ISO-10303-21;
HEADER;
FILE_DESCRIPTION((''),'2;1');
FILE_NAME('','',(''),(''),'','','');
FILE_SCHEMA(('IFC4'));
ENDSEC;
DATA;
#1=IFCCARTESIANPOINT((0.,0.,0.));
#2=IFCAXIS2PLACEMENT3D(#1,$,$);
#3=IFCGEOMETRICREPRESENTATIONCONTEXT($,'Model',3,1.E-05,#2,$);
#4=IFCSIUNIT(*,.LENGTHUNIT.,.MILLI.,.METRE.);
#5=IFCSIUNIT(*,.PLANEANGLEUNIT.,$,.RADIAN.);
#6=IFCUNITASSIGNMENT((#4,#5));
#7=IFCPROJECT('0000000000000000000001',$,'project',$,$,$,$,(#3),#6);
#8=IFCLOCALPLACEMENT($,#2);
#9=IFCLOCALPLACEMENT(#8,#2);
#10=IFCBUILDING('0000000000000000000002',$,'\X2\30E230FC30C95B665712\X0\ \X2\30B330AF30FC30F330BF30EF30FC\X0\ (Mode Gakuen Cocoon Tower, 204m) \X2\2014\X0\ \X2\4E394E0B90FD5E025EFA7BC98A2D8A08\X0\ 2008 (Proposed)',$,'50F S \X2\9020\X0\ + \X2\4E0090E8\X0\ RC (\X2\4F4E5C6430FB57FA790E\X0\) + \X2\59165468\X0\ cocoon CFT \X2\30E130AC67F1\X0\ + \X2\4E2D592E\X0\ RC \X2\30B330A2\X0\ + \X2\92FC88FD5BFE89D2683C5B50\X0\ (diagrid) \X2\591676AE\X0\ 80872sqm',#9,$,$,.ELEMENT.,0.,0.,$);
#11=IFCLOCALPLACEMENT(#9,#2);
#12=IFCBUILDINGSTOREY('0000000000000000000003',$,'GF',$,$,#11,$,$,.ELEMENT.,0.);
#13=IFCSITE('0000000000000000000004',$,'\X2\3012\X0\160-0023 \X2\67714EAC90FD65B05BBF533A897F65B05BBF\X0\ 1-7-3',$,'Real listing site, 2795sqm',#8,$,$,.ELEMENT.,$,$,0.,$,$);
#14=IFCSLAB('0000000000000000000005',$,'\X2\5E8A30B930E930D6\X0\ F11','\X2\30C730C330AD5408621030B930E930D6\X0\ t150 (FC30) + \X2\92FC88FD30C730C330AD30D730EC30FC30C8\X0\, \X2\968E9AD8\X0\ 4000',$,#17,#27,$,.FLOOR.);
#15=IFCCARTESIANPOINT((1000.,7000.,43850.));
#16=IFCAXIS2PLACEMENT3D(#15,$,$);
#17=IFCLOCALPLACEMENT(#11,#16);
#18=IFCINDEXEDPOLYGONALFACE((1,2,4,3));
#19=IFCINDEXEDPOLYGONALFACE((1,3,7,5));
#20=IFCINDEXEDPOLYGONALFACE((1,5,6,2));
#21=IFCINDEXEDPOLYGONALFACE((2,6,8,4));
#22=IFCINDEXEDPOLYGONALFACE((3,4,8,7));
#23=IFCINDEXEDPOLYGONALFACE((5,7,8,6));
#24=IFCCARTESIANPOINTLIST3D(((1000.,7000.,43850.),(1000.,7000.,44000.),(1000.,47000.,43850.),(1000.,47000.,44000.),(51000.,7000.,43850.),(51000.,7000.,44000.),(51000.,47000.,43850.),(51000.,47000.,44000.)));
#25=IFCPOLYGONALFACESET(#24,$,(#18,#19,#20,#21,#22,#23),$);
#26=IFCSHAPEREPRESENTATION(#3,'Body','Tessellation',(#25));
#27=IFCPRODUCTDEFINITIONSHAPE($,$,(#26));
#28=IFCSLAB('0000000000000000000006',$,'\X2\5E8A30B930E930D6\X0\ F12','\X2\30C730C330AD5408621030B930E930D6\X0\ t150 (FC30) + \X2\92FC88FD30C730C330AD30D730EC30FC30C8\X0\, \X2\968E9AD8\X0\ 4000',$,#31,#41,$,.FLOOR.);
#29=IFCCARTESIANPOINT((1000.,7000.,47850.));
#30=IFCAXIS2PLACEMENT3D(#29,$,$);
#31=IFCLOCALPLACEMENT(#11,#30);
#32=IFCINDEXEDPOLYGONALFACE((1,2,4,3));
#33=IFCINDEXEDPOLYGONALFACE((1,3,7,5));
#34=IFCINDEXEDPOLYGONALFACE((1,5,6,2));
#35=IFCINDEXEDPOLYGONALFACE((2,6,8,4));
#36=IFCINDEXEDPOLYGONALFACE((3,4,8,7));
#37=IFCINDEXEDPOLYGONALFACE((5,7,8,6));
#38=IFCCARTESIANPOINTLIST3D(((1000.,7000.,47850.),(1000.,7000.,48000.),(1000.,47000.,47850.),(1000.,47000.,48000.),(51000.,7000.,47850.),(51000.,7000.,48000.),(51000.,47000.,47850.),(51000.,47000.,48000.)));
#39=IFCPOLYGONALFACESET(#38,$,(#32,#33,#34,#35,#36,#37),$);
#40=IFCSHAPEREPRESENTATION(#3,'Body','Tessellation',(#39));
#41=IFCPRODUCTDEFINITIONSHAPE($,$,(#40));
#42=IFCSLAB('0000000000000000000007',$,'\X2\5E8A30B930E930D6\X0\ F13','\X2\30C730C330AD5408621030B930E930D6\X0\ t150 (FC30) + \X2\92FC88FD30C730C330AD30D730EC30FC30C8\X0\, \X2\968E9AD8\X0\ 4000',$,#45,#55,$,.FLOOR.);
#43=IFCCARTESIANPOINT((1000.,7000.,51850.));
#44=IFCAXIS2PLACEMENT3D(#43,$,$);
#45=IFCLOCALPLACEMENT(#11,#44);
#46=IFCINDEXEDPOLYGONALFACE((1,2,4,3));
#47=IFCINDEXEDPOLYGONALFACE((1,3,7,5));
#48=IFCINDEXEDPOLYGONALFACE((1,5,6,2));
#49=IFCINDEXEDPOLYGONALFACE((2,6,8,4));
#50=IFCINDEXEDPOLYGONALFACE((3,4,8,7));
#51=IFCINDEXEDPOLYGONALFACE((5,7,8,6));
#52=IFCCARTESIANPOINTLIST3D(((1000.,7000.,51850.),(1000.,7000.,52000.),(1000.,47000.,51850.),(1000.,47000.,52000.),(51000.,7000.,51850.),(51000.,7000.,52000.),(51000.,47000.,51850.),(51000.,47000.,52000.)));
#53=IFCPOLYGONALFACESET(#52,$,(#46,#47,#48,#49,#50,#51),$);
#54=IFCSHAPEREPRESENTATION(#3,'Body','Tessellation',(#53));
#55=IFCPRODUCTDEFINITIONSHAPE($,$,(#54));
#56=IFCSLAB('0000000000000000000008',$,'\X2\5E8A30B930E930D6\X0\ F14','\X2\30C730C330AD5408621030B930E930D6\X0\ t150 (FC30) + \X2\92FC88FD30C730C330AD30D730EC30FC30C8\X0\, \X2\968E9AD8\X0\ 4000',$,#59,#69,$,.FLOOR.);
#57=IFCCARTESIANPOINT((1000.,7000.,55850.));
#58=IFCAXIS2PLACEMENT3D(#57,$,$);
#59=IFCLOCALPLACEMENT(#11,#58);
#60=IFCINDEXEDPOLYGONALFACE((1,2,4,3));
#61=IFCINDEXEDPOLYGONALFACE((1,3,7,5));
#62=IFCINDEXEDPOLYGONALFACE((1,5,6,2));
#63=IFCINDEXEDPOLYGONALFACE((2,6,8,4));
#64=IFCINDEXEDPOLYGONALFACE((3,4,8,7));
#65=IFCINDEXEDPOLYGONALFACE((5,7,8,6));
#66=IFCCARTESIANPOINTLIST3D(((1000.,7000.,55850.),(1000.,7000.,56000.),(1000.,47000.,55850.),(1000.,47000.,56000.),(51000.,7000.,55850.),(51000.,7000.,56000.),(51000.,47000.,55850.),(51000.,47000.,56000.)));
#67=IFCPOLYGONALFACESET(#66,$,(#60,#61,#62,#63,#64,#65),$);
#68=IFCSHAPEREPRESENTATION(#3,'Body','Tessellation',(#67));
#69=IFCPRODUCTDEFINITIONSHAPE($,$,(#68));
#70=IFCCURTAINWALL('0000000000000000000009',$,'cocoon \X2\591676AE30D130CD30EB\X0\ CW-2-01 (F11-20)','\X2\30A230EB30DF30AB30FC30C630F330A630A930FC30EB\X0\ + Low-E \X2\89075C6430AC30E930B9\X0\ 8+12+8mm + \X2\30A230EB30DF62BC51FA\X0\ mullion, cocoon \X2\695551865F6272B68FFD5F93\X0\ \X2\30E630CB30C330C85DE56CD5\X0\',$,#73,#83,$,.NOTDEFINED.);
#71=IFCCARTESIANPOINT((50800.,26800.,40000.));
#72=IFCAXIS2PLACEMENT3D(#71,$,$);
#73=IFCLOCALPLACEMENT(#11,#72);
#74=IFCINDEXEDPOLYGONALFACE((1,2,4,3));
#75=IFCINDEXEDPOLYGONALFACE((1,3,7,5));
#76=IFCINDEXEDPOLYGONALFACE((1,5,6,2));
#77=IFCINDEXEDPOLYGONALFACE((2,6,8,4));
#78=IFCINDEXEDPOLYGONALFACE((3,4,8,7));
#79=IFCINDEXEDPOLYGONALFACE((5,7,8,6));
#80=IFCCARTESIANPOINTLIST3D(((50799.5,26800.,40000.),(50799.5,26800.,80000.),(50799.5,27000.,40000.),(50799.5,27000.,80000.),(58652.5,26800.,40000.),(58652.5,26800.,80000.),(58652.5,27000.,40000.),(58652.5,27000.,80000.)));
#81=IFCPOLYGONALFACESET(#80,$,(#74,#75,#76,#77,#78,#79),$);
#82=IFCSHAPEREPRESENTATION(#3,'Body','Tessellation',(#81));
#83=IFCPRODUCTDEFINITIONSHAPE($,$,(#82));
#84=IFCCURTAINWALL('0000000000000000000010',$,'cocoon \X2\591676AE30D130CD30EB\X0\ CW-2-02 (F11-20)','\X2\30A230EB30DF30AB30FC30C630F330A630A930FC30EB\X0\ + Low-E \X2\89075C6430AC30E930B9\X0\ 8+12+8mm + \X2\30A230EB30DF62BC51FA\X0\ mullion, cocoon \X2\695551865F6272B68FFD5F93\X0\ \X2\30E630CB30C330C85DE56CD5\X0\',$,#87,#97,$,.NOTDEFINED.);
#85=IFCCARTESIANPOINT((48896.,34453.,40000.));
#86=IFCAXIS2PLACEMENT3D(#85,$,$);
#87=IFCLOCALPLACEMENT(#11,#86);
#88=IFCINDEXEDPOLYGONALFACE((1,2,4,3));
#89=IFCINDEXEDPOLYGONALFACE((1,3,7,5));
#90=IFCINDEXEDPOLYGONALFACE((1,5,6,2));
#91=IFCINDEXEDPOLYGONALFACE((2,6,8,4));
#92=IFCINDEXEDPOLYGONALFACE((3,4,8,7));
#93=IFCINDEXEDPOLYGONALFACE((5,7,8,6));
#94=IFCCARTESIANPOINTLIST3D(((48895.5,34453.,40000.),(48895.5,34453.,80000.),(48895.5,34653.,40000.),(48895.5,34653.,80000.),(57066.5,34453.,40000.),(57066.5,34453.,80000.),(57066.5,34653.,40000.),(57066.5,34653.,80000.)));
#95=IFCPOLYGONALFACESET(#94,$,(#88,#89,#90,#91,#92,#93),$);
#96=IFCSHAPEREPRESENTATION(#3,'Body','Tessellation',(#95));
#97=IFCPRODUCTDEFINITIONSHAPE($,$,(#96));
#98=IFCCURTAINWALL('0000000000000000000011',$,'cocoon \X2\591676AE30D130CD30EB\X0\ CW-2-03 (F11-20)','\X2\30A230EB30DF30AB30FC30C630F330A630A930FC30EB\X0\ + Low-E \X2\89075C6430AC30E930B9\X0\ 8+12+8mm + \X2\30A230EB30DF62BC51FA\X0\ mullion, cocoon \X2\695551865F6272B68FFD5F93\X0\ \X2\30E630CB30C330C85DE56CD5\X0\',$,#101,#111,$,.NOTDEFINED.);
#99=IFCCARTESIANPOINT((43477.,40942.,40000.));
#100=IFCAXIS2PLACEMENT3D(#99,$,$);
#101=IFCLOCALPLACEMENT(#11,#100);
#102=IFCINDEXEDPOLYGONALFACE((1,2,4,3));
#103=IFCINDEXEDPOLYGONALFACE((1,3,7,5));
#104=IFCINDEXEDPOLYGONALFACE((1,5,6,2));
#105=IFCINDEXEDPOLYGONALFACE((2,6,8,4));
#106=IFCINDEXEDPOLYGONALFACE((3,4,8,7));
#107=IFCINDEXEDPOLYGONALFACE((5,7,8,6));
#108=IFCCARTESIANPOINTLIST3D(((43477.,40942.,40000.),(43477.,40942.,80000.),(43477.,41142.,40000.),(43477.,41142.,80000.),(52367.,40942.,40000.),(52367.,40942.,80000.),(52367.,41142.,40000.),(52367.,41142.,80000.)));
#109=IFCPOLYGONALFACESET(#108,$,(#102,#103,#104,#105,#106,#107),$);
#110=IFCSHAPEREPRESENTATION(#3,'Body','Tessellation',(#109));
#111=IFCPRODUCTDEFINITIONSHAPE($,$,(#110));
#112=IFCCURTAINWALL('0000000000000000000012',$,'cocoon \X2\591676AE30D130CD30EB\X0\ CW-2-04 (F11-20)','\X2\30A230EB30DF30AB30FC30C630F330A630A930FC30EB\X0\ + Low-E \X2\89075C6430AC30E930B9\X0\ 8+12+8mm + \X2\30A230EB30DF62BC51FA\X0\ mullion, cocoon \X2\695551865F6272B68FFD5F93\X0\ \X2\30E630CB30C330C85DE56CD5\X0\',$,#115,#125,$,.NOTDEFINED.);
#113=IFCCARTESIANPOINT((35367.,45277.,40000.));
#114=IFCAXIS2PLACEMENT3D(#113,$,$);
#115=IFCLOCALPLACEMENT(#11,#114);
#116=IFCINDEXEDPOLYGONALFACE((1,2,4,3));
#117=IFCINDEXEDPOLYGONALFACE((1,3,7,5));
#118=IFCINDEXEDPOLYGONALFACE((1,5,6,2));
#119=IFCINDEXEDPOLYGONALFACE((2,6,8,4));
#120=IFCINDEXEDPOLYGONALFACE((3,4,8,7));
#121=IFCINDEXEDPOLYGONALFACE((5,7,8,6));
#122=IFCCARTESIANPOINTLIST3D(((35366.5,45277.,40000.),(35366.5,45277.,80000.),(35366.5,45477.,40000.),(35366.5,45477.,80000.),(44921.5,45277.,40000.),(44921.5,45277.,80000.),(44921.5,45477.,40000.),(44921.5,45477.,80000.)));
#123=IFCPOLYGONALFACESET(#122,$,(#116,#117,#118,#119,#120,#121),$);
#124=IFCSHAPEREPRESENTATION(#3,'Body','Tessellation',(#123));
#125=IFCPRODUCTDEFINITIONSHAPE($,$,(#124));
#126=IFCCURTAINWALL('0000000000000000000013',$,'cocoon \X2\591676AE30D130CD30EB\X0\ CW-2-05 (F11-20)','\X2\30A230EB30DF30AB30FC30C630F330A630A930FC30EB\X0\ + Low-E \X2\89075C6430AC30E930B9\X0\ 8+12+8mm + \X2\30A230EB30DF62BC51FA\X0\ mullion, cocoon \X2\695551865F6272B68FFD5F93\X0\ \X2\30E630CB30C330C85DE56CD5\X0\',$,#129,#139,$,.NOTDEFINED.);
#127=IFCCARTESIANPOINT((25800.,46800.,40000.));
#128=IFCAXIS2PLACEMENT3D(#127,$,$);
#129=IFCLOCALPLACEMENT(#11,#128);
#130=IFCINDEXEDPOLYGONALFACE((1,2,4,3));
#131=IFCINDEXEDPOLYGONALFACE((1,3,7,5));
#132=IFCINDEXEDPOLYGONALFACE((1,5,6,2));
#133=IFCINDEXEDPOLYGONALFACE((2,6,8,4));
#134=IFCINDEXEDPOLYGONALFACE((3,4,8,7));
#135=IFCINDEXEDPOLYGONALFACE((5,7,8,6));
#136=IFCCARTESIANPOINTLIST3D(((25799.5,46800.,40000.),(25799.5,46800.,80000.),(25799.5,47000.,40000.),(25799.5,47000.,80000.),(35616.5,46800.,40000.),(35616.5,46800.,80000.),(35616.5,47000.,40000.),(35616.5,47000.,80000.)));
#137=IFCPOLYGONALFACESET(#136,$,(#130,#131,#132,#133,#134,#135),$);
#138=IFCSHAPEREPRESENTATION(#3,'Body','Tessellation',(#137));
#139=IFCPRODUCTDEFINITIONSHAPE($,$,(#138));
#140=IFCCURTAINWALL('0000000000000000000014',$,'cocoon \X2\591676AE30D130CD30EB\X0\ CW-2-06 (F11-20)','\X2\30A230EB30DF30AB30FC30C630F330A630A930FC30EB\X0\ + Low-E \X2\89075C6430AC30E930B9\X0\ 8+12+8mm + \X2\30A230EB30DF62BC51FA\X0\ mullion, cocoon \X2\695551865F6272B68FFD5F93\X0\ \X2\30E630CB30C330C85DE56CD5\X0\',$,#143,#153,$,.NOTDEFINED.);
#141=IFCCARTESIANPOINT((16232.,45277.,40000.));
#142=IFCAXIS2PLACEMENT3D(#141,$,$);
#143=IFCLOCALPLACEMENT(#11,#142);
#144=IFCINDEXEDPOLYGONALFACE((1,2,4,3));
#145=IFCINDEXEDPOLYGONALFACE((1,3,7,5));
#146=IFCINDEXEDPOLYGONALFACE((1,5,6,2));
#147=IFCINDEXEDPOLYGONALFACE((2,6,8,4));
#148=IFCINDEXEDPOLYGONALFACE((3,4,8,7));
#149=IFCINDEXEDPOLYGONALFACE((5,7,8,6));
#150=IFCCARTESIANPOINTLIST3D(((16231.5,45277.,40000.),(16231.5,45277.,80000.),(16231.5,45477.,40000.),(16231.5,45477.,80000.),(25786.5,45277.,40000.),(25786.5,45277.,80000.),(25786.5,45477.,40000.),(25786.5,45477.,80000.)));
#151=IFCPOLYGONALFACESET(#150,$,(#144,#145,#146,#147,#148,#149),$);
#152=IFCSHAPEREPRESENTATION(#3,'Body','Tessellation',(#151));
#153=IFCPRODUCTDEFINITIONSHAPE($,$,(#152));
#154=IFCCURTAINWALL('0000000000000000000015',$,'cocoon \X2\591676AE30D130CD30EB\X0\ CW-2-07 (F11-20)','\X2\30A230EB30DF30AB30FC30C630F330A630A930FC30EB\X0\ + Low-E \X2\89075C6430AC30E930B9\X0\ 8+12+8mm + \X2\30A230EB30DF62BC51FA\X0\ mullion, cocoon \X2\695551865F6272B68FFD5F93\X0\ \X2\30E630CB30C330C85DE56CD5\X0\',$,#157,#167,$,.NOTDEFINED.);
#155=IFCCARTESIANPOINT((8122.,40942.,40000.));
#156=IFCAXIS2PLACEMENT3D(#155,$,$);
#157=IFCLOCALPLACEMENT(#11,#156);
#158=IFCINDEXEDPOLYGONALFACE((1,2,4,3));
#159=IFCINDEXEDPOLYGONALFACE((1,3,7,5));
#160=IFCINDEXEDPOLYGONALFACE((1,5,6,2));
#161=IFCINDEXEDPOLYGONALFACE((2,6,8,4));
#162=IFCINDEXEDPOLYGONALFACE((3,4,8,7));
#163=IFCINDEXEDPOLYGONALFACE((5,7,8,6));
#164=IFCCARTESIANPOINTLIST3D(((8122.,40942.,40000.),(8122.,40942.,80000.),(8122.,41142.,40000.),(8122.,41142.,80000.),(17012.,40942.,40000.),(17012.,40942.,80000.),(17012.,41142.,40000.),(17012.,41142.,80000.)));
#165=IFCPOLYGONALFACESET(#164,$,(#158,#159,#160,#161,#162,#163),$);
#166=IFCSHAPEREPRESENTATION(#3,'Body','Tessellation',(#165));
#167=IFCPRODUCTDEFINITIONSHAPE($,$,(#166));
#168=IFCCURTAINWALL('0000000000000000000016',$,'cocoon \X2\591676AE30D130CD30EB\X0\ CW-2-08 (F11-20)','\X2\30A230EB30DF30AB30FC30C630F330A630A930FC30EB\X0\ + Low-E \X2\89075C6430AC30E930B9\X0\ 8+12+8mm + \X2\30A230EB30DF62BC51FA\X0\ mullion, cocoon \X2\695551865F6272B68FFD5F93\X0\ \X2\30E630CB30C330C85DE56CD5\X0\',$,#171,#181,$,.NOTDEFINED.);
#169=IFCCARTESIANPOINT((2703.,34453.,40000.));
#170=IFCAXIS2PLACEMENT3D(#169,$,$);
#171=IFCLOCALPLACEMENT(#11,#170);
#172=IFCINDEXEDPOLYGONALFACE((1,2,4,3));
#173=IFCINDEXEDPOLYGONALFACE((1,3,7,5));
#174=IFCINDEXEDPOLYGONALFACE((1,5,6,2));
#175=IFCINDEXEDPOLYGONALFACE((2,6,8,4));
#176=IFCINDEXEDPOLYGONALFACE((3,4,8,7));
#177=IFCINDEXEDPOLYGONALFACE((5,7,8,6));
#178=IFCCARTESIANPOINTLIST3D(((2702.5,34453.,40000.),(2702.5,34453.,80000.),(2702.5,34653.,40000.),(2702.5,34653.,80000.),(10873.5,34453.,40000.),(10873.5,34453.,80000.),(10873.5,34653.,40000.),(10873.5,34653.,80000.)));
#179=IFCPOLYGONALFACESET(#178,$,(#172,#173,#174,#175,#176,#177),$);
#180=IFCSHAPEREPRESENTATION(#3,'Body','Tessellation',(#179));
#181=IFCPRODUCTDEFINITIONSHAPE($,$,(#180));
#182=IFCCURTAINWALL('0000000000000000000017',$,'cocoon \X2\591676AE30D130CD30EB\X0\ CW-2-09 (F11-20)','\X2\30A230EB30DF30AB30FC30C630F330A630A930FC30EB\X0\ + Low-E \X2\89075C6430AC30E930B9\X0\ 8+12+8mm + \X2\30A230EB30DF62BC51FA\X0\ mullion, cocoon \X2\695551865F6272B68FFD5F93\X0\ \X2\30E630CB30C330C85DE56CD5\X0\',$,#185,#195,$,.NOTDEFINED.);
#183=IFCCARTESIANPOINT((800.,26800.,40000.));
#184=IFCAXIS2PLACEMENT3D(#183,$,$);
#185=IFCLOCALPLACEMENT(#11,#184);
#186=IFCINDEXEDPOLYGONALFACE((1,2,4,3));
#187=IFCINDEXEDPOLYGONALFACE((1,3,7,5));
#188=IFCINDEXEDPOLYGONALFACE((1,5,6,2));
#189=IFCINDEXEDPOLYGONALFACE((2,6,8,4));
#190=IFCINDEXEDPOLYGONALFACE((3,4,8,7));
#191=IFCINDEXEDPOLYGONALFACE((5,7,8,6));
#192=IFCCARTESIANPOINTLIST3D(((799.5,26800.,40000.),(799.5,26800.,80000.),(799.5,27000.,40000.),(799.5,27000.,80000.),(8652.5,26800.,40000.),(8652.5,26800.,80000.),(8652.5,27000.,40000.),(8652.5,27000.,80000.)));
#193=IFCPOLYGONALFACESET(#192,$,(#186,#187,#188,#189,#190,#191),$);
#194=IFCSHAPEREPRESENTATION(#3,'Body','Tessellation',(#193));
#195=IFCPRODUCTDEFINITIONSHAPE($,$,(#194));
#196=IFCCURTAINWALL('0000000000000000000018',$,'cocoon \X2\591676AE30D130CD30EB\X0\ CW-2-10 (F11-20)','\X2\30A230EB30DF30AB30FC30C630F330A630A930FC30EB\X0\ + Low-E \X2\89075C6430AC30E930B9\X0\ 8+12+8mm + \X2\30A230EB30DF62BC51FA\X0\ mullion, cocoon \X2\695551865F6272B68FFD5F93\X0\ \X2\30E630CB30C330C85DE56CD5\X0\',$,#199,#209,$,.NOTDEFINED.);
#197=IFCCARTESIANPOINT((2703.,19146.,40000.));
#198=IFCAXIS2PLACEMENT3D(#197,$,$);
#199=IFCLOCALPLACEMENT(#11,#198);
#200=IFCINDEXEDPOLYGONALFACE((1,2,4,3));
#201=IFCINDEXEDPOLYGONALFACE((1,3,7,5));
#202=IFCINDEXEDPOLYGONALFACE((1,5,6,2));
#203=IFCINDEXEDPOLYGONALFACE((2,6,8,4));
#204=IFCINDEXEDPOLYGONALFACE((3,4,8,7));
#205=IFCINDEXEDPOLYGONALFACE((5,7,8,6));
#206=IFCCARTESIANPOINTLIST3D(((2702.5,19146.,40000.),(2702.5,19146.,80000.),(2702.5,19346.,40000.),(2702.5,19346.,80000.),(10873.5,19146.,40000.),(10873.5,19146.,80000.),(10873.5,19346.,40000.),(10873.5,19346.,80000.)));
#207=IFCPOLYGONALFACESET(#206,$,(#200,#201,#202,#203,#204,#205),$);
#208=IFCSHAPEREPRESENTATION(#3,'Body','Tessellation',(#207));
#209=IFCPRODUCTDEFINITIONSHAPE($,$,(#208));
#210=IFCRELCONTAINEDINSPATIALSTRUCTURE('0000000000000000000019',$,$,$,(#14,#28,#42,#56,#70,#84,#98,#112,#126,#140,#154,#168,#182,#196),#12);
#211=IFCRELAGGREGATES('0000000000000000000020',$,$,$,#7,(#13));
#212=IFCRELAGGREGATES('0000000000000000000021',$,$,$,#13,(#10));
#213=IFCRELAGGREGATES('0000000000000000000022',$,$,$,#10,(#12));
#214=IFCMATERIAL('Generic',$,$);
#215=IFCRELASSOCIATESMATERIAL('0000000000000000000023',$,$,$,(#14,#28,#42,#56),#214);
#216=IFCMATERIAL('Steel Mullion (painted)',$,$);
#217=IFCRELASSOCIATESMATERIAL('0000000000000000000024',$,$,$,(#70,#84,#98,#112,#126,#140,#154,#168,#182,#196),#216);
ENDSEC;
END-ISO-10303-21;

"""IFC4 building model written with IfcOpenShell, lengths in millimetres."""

from ifc_helpers import new_model, si_unit, frame, frame_2d, origin, place, context, project, spatial, rectangle, extrude, material, element, save


model = new_model("IFC4")

# Units and contexts
model_context = context("Model", 3, precision=1e-05, world=origin())
ifc_project = project(units=[si_unit("LENGTHUNIT", "METRE", prefix="MILLI"), si_unit("PLANEANGLEUNIT", "RADIAN")], contexts=[model_context])

# Site, building, storey
site_placement = place(None, origin())
site = spatial("IfcSite", under=ifc_project, at=site_placement, Name="〒160-0023 東京都新宿区西新宿 1-7-3", ObjectType="Real listing site, 2795sqm", CompositionType="ELEMENT", RefElevation=0.0)
building_placement = place(site_placement, origin())
building = spatial("IfcBuilding", under=site, at=building_placement, Name="モード学園 コクーンタワー (Mode Gakuen Cocoon Tower, 204m) — 丹下都市建築設計 2008 (Proposed)", ObjectType="50F S 造 + 一部 RC (低層・基礎) + 外周 cocoon CFT メガ柱 + 中央 RC コア + 鋼製対角格子 (diagrid) 外皮 80872sqm", CompositionType="ELEMENT", ElevationOfRefHeight=0.0, ElevationOfTerrain=0.0)
storey_placement = place(building_placement, origin())
storey = spatial("IfcBuildingStorey", under=building, at=storey_placement, Name="GF", CompositionType="ELEMENT", Elevation=0.0)

# Slabs
ifc_material_1 = material(Name="Generic")
slab_1_placement = place(storey_placement, frame((1000.0, 7000.0, 43850.0)))
element("IfcSlab", 1, at=slab_1_placement, inside=storey, material=ifc_material_1, Name="床スラブ F11", Description="デッキ合成スラブ t150 (FC30) + 鋼製デッキプレート, 階高 4000", PredefinedType="FLOOR", context=model_context, shape_type="SweptSolid", body=[
    extrude(rectangle(XDim=50000.0, YDim=40000.0, at=frame_2d((25000.0, 20000.0))), frame((1000.0, 7000.0, 43850.0)), (0.0, 0.0, 1.0), 150.0),
])
slab_2_placement = place(storey_placement, frame((1000.0, 7000.0, 47850.0)))
element("IfcSlab", 2, at=slab_2_placement, inside=storey, material=ifc_material_1, Name="床スラブ F12", Description="デッキ合成スラブ t150 (FC30) + 鋼製デッキプレート, 階高 4000", PredefinedType="FLOOR", context=model_context, shape_type="SweptSolid", body=[
    extrude(rectangle(XDim=50000.0, YDim=40000.0, at=frame_2d((25000.0, 20000.0))), frame((1000.0, 7000.0, 47850.0)), (0.0, 0.0, 1.0), 150.0),
])
slab_3_placement = place(storey_placement, frame((1000.0, 7000.0, 51850.0)))
element("IfcSlab", 3, at=slab_3_placement, inside=storey, material=ifc_material_1, Name="床スラブ F13", Description="デッキ合成スラブ t150 (FC30) + 鋼製デッキプレート, 階高 4000", PredefinedType="FLOOR", context=model_context, shape_type="SweptSolid", body=[
    extrude(rectangle(XDim=50000.0, YDim=40000.0, at=frame_2d((25000.0, 20000.0))), frame((1000.0, 7000.0, 51850.0)), (0.0, 0.0, 1.0), 150.0),
])
slab_4_placement = place(storey_placement, frame((1000.0, 7000.0, 55850.0)))
element("IfcSlab", 4, at=slab_4_placement, inside=storey, material=ifc_material_1, Name="床スラブ F14", Description="デッキ合成スラブ t150 (FC30) + 鋼製デッキプレート, 階高 4000", PredefinedType="FLOOR", context=model_context, shape_type="SweptSolid", body=[
    extrude(rectangle(XDim=50000.0, YDim=40000.0, at=frame_2d((25000.0, 20000.0))), frame((1000.0, 7000.0, 55850.0)), (0.0, 0.0, 1.0), 150.0),
])

# Curtain walls
ifc_material_2 = material(Name="Steel Mullion (painted)")
curtain_wall_1_placement = place(storey_placement, frame((50800.0, 26800.0, 40000.0)))
element("IfcCurtainWall", 5, at=curtain_wall_1_placement, inside=storey, material=ifc_material_2, Name="cocoon 外皮パネル CW-2-01 (F11-20)", Description="アルミカーテンウォール + Low-E 複層ガラス 8+12+8mm + アルミ押出 mullion, cocoon 楕円形状追従 ユニット工法", PredefinedType="NOTDEFINED", context=model_context, shape_type="SweptSolid", body=[
    extrude(rectangle(XDim=7853.0, YDim=200.0, at=frame_2d((3926.0, 100.0))), frame((50800.0, 26800.0, 40000.0)), (0.0, 0.0, 1.0), 40000.0),
])
curtain_wall_2_placement = place(storey_placement, frame((48896.0, 34453.0, 40000.0)))
element("IfcCurtainWall", 6, at=curtain_wall_2_placement, inside=storey, material=ifc_material_2, Name="cocoon 外皮パネル CW-2-02 (F11-20)", Description="アルミカーテンウォール + Low-E 複層ガラス 8+12+8mm + アルミ押出 mullion, cocoon 楕円形状追従 ユニット工法", PredefinedType="NOTDEFINED", context=model_context, shape_type="SweptSolid", body=[
    extrude(rectangle(XDim=8171.0, YDim=200.0, at=frame_2d((4085.0, 100.0))), frame((48896.0, 34453.0, 40000.0)), (0.0, 0.0, 1.0), 40000.0),
])
curtain_wall_3_placement = place(storey_placement, frame((43477.0, 40942.0, 40000.0)))
element("IfcCurtainWall", 7, at=curtain_wall_3_placement, inside=storey, material=ifc_material_2, Name="cocoon 外皮パネル CW-2-03 (F11-20)", Description="アルミカーテンウォール + Low-E 複層ガラス 8+12+8mm + アルミ押出 mullion, cocoon 楕円形状追従 ユニット工法", PredefinedType="NOTDEFINED", context=model_context, shape_type="SweptSolid", body=[
    extrude(rectangle(XDim=8890.0, YDim=200.0, at=frame_2d((4445.0, 100.0))), frame((43477.0, 40942.0, 40000.0)), (0.0, 0.0, 1.0), 40000.0),
])
curtain_wall_4_placement = place(storey_placement, frame((35367.0, 45277.0, 40000.0)))
element("IfcCurtainWall", 8, at=curtain_wall_4_placement, inside=storey, material=ifc_material_2, Name="cocoon 外皮パネル CW-2-04 (F11-20)", Description="アルミカーテンウォール + Low-E 複層ガラス 8+12+8mm + アルミ押出 mullion, cocoon 楕円形状追従 ユニット工法", PredefinedType="NOTDEFINED", context=model_context, shape_type="SweptSolid", body=[
    extrude(rectangle(XDim=9555.0, YDim=200.0, at=frame_2d((4777.0, 100.0))), frame((35367.0, 45277.0, 40000.0)), (0.0, 0.0, 1.0), 40000.0),
])
curtain_wall_5_placement = place(storey_placement, frame((25800.0, 46800.0, 40000.0)))
element("IfcCurtainWall", 9, at=curtain_wall_5_placement, inside=storey, material=ifc_material_2, Name="cocoon 外皮パネル CW-2-05 (F11-20)", Description="アルミカーテンウォール + Low-E 複層ガラス 8+12+8mm + アルミ押出 mullion, cocoon 楕円形状追従 ユニット工法", PredefinedType="NOTDEFINED", context=model_context, shape_type="SweptSolid", body=[
    extrude(rectangle(XDim=9817.0, YDim=200.0, at=frame_2d((4908.0, 100.0))), frame((25800.0, 46800.0, 40000.0)), (0.0, 0.0, 1.0), 40000.0),
])
curtain_wall_6_placement = place(storey_placement, frame((16232.0, 45277.0, 40000.0)))
element("IfcCurtainWall", 10, at=curtain_wall_6_placement, inside=storey, material=ifc_material_2, Name="cocoon 外皮パネル CW-2-06 (F11-20)", Description="アルミカーテンウォール + Low-E 複層ガラス 8+12+8mm + アルミ押出 mullion, cocoon 楕円形状追従 ユニット工法", PredefinedType="NOTDEFINED", context=model_context, shape_type="SweptSolid", body=[
    extrude(rectangle(XDim=9555.0, YDim=200.0, at=frame_2d((4777.0, 100.0))), frame((16232.0, 45277.0, 40000.0)), (0.0, 0.0, 1.0), 40000.0),
])
curtain_wall_7_placement = place(storey_placement, frame((8122.0, 40942.0, 40000.0)))
element("IfcCurtainWall", 11, at=curtain_wall_7_placement, inside=storey, material=ifc_material_2, Name="cocoon 外皮パネル CW-2-07 (F11-20)", Description="アルミカーテンウォール + Low-E 複層ガラス 8+12+8mm + アルミ押出 mullion, cocoon 楕円形状追従 ユニット工法", PredefinedType="NOTDEFINED", context=model_context, shape_type="SweptSolid", body=[
    extrude(rectangle(XDim=8890.0, YDim=200.0, at=frame_2d((4445.0, 100.0))), frame((8122.0, 40942.0, 40000.0)), (0.0, 0.0, 1.0), 40000.0),
])
curtain_wall_8_placement = place(storey_placement, frame((2703.0, 34453.0, 40000.0)))
element("IfcCurtainWall", 12, at=curtain_wall_8_placement, inside=storey, material=ifc_material_2, Name="cocoon 外皮パネル CW-2-08 (F11-20)", Description="アルミカーテンウォール + Low-E 複層ガラス 8+12+8mm + アルミ押出 mullion, cocoon 楕円形状追従 ユニット工法", PredefinedType="NOTDEFINED", context=model_context, shape_type="SweptSolid", body=[
    extrude(rectangle(XDim=8171.0, YDim=200.0, at=frame_2d((4085.0, 100.0))), frame((2703.0, 34453.0, 40000.0)), (0.0, 0.0, 1.0), 40000.0),
])
curtain_wall_9_placement = place(storey_placement, frame((800.0, 26800.0, 40000.0)))
element("IfcCurtainWall", 13, at=curtain_wall_9_placement, inside=storey, material=ifc_material_2, Name="cocoon 外皮パネル CW-2-09 (F11-20)", Description="アルミカーテンウォール + Low-E 複層ガラス 8+12+8mm + アルミ押出 mullion, cocoon 楕円形状追従 ユニット工法", PredefinedType="NOTDEFINED", context=model_context, shape_type="SweptSolid", body=[
    extrude(rectangle(XDim=7853.0, YDim=200.0, at=frame_2d((3926.0, 100.0))), frame((800.0, 26800.0, 40000.0)), (0.0, 0.0, 1.0), 40000.0),
])
curtain_wall_10_placement = place(storey_placement, frame((2703.0, 19146.0, 40000.0)))
element("IfcCurtainWall", 14, at=curtain_wall_10_placement, inside=storey, material=ifc_material_2, Name="cocoon 外皮パネル CW-2-10 (F11-20)", Description="アルミカーテンウォール + Low-E 複層ガラス 8+12+8mm + アルミ押出 mullion, cocoon 楕円形状追従 ユニット工法", PredefinedType="NOTDEFINED", context=model_context, shape_type="SweptSolid", body=[
    extrude(rectangle(XDim=8171.0, YDim=200.0, at=frame_2d((4085.0, 100.0))), frame((2703.0, 19146.0, 40000.0)), (0.0, 0.0, 1.0), 40000.0),
])

save(model, "model.ifc")
